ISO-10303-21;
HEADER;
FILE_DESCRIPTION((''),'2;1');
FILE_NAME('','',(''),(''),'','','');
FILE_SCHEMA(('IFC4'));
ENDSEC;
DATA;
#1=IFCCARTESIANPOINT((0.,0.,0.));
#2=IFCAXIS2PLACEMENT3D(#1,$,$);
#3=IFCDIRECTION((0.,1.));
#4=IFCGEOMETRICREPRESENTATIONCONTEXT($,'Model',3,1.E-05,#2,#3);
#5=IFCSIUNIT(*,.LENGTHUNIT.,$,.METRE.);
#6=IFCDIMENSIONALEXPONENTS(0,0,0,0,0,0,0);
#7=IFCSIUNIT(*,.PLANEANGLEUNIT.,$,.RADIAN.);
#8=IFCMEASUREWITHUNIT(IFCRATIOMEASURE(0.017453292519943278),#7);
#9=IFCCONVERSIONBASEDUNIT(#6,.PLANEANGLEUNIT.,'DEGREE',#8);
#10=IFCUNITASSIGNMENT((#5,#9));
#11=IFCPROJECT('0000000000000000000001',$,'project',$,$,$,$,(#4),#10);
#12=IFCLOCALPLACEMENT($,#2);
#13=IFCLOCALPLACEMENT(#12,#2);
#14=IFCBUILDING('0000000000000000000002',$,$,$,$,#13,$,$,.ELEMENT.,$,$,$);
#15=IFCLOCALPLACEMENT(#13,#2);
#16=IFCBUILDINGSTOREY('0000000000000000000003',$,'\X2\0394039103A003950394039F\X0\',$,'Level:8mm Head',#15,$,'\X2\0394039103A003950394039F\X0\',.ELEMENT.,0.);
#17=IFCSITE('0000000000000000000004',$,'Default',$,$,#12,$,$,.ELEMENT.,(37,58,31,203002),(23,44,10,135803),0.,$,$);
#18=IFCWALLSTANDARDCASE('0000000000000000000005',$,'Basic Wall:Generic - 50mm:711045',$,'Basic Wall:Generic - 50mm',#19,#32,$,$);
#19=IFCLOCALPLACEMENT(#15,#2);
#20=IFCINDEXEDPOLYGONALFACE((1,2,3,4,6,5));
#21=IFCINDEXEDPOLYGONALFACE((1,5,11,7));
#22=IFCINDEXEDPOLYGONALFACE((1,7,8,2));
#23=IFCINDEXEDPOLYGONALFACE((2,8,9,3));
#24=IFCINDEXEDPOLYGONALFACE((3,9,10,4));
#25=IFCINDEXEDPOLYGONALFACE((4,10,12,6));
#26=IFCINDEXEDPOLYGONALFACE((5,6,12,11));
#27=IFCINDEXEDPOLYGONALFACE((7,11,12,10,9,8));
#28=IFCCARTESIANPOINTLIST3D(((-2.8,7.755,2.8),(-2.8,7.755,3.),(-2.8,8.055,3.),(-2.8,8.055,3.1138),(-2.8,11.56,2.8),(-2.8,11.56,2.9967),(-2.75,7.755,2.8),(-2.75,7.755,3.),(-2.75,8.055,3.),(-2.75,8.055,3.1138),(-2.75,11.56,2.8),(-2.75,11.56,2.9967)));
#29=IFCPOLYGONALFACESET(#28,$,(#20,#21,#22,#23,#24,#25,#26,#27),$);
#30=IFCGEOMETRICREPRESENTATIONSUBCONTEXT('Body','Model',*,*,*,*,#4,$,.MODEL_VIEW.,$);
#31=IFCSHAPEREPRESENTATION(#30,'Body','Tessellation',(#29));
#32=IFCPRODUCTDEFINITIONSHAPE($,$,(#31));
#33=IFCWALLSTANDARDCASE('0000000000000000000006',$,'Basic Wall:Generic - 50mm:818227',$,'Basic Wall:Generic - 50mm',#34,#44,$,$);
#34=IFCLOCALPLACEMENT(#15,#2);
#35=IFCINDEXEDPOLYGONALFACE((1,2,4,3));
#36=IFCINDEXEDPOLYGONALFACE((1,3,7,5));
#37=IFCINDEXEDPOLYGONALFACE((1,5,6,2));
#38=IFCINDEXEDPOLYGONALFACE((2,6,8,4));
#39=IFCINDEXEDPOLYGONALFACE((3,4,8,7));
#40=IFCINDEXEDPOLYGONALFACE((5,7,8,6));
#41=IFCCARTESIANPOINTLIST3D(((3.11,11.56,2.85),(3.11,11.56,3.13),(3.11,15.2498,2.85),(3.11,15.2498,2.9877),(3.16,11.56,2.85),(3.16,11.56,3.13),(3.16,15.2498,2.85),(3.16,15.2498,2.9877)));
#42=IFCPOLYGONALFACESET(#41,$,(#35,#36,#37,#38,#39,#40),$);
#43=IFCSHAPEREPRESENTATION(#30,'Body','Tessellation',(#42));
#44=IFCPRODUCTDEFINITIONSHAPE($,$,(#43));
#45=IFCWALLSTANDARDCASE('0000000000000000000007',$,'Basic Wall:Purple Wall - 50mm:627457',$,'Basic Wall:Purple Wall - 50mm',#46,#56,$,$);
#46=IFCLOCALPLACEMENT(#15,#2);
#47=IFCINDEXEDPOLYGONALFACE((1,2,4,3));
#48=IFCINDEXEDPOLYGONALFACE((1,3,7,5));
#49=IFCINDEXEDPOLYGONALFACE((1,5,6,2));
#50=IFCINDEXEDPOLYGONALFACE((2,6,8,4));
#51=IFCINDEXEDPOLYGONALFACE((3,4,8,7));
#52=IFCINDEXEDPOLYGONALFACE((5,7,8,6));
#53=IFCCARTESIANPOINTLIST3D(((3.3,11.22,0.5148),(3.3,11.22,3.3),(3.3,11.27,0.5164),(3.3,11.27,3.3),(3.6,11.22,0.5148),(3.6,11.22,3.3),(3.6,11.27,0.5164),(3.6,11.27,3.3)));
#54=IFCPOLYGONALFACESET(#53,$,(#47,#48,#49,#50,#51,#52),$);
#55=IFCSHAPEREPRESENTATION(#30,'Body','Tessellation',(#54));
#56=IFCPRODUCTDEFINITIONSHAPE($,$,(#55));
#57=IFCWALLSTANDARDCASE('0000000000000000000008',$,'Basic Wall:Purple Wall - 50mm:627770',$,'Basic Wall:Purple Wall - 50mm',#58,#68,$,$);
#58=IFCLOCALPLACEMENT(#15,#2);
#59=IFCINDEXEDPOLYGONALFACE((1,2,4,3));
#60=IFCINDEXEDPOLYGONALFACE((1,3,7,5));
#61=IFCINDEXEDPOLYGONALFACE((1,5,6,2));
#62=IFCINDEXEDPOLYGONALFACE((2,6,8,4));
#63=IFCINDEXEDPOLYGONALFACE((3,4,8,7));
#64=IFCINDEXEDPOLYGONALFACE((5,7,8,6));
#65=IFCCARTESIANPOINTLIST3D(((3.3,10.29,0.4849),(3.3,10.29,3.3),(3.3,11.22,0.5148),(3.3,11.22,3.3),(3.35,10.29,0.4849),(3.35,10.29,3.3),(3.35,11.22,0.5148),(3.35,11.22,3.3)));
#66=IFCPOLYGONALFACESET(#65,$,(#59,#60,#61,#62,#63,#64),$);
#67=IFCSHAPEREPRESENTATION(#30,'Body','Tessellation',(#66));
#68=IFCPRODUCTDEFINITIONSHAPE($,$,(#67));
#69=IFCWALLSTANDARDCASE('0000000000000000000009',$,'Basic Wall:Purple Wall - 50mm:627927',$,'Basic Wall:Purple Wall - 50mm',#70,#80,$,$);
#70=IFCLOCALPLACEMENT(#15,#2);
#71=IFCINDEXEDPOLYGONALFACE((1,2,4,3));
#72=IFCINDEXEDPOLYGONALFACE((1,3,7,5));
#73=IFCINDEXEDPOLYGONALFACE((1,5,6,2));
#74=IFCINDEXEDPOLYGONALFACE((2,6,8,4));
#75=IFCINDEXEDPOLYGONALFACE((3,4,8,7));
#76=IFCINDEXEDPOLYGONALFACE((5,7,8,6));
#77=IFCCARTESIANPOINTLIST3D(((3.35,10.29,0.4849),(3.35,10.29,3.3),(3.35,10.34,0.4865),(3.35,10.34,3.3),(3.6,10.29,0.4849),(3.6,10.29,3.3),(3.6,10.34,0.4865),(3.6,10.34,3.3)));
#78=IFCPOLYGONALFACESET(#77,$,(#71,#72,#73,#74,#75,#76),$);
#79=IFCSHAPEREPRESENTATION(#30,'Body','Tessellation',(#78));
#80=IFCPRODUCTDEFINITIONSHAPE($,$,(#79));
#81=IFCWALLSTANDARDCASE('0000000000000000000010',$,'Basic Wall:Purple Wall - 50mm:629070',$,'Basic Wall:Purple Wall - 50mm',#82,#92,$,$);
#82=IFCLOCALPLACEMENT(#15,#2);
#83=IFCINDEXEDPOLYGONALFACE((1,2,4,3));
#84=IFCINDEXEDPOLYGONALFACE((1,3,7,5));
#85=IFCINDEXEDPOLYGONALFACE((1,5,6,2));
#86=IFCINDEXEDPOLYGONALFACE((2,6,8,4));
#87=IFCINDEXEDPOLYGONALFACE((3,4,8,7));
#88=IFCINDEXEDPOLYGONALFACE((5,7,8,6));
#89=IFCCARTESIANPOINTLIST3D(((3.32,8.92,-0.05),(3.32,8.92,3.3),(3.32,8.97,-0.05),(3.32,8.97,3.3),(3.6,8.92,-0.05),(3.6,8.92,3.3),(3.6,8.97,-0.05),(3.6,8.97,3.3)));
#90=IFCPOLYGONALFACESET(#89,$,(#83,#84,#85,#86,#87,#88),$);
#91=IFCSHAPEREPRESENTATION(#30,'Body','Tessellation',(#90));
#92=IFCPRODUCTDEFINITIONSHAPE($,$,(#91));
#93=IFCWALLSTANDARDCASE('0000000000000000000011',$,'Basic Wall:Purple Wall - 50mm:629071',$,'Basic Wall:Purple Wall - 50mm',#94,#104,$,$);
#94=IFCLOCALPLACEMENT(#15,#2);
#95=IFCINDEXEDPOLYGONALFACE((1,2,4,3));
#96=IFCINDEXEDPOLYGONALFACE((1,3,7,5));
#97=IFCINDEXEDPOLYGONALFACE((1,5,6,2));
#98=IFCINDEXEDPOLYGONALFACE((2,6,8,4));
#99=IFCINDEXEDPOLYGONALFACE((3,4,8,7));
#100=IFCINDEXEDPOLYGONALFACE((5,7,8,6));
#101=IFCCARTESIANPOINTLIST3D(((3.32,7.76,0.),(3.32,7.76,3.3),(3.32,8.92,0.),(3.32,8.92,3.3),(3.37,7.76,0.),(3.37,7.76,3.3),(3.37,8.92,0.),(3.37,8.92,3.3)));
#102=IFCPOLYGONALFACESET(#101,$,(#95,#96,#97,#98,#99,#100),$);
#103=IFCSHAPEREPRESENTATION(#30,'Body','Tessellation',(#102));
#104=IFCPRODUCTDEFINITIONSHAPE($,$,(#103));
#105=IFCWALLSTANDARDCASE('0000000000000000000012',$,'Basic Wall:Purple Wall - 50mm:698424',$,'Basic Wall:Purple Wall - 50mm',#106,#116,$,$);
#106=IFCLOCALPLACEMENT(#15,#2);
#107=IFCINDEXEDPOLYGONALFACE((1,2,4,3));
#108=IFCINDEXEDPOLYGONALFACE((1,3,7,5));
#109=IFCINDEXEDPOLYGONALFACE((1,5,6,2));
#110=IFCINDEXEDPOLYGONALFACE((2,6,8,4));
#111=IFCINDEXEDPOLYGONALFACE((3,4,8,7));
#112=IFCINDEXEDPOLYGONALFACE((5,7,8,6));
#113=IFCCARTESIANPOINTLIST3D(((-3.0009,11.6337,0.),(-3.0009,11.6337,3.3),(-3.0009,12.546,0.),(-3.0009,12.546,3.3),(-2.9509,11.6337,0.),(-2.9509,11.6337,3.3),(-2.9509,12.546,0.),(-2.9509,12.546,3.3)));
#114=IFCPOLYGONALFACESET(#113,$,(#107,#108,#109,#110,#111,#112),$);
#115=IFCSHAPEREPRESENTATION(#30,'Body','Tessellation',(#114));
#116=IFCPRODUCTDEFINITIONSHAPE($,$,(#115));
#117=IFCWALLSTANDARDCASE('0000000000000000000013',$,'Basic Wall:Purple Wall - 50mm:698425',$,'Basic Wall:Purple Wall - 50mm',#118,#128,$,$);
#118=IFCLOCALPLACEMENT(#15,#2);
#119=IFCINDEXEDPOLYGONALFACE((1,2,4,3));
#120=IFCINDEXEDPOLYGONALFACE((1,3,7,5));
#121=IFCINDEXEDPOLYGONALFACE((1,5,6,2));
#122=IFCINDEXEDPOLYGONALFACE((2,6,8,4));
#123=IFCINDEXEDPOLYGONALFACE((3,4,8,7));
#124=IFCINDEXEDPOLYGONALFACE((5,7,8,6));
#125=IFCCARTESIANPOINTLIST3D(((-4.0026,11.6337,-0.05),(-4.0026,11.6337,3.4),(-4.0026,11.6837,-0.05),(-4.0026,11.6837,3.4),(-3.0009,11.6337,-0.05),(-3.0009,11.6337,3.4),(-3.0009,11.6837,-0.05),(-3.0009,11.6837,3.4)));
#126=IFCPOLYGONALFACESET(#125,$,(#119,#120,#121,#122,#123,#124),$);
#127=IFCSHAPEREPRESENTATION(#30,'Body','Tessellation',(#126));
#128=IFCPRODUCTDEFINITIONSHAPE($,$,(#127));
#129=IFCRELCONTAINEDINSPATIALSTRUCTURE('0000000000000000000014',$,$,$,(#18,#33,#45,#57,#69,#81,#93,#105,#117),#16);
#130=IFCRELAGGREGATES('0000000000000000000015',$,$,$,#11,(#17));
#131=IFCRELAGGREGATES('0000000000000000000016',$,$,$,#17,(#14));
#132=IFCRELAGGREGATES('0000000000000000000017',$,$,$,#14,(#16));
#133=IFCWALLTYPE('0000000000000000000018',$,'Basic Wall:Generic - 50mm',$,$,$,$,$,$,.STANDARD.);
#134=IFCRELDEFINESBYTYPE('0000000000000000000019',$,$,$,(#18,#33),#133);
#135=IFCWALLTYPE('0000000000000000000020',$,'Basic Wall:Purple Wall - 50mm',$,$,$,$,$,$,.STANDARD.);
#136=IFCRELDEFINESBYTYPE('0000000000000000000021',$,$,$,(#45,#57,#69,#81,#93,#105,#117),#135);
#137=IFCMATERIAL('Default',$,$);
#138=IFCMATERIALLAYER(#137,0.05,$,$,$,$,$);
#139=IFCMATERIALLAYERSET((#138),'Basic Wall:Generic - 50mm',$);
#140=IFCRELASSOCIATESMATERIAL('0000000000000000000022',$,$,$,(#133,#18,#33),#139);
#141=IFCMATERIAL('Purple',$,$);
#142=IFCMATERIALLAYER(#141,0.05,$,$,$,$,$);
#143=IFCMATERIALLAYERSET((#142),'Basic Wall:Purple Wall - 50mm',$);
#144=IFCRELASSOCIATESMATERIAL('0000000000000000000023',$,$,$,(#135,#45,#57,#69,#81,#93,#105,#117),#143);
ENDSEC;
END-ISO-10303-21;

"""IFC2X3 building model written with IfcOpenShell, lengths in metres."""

from ifc_helpers import new_model, entity, si_unit, converted_unit, direction, frame, frame_2d, origin, place, context, subcontext, project, spatial, polyline, rectangle, extrude, clip, bounded_halfspace, material, layer, layer_set, layer_usage, type_object, element, save


model = new_model("IFC2X3")

# Units and contexts
model_context = context("Model", 3, precision=1e-05, world=origin(), true_north=direction((0.0, 1.0)))
body_context = subcontext(model_context, "Body", "Model", "MODEL_VIEW")
ifc_project = project(units=[si_unit("LENGTHUNIT", "METRE"), converted_unit("PLANEANGLEUNIT", "DEGREE", entity("IfcRatioMeasure", 0.017453292519943278), si_unit("PLANEANGLEUNIT", "RADIAN"), dimensions=[0, 0, 0, 0, 0, 0, 0])], contexts=[model_context])

# Site, building, storey
site_placement = place(None, origin())
site = spatial("IfcSite", under=ifc_project, at=site_placement, Name="Default", CompositionType="ELEMENT", RefLatitude=(37, 58, 31, 203002), RefLongitude=(23, 44, 10, 135803), RefElevation=0.0)
building_placement = place(site_placement, origin())
building = spatial("IfcBuilding", under=site, at=building_placement, CompositionType="ELEMENT")
storey_placement = place(building_placement, origin())
storey = spatial("IfcBuildingStorey", under=building, at=storey_placement, Name="ΔΑΠΕΔΟ", ObjectType="Level:8mm Head", LongName="ΔΑΠΕΔΟ", CompositionType="ELEMENT", Elevation=0.0)

# Walls
ifc_material_1 = material(Name="Default")
ifc_layer_1 = layer(ifc_material_1, 0.05)
ifc_layer_set_1 = layer_set([ifc_layer_1], Name="Basic Wall:Generic - 50mm")
ifc_layer_usage_1 = layer_usage(ifc_layer_set_1, "AXIS2", "NEGATIVE", 0.025)
wall_type_1 = type_object("IfcWallType", Name="Basic Wall:Generic - 50mm", PredefinedType="STANDARD", material=ifc_layer_set_1)
wall_1_placement = place(storey_placement, frame((-2.775, 11.56, 2.8), z_axis=(0.0, 0.0, 1.0), x_axis=(0.0, -1.0, 0.0)))
element("IfcWallStandardCase", 1, at=wall_1_placement, inside=storey, type_object=wall_type_1, material=ifc_layer_usage_1, Name="Basic Wall:Generic - 50mm:711045", ObjectType="Basic Wall:Generic - 50mm", context=body_context, shape_type="Clipping", body=[
    clip(clip(clip(extrude(rectangle(XDim=3.805, YDim=0.05, at=frame_2d((1.9025, 0.0), x_axis=(-1.0, 0.0))), origin(), (0.0, 0.0, 1.0), 0.3138), bounded_halfspace(frame((0.0, -0.025, 0.1967), z_axis=(0.033402, 0.0, -0.999442), x_axis=(-0.999442, 0.0, -0.033402)), True, frame((0.0, -0.025, 0.1967)), polyline([(0.0, 0.0), (3.505, 0.0), (3.505, 0.05), (0.0, 0.05), (0.0, 0.0)]))), bounded_halfspace(frame((3.505, -0.025, 0.2), z_axis=(0.0, 0.0, -1.0), x_axis=(0.0, 1.0, 0.0)), True, frame((3.505, -0.025, 0.2)), polyline([(0.0, 0.0), (0.3, 0.0), (0.3, 0.05), (0.0, 0.05), (0.0, 0.0)]))), bounded_halfspace(frame((3.505, -0.025, 0.2), z_axis=(0.0, 0.0, -1.0), x_axis=(0.0, 1.0, 0.0)), True, frame((3.505, -0.025, 0.2)), polyline([(0.0, 0.0), (0.3, 0.0), (0.3, 0.05), (0.0, 0.05), (0.0, 0.0)]))),
])
wall_2_placement = place(storey_placement, frame((3.135, 11.56, 2.85), z_axis=(0.0, 0.0, 1.0), x_axis=(0.0, 1.0, 0.0)))
element("IfcWallStandardCase", 2, at=wall_2_placement, inside=storey, type_object=wall_type_1, material=ifc_layer_usage_1, Name="Basic Wall:Generic - 50mm:818227", ObjectType="Basic Wall:Generic - 50mm", context=body_context, shape_type="Clipping", body=[
    clip(extrude(rectangle(XDim=3.6898, YDim=0.05, at=frame_2d((1.8449, 0.0), x_axis=(-1.0, 0.0))), origin(), (0.0, 0.0, 1.0), 0.28), bounded_halfspace(frame((0.0, -0.025, 0.28), z_axis=(-0.038534, 0.0, -0.999257), x_axis=(0.999257, 0.0, -0.038534)), True, frame((0.0, -0.025, 0.28)), polyline([(0.0, 0.0), (3.6898, 0.0), (3.6898, 0.05), (0.0, 0.05), (0.0, 0.0)]))),
])
ifc_material_2 = material(Name="Purple")
ifc_layer_2 = layer(ifc_material_2, 0.05)
ifc_layer_set_2 = layer_set([ifc_layer_2], Name="Basic Wall:Purple Wall - 50mm")
ifc_layer_usage_2 = layer_usage(ifc_layer_set_2, "AXIS2", "POSITIVE", -0.025)
wall_type_2 = type_object("IfcWallType", Name="Basic Wall:Purple Wall - 50mm", PredefinedType="STANDARD", material=ifc_layer_set_2)
wall_3_placement = place(storey_placement, frame((3.6, 11.245, 0.5148), z_axis=(0.0, 0.0, 1.0), x_axis=(-1.0, 0.0, 0.0)))
element("IfcWallStandardCase", 3, at=wall_3_placement, inside=storey, type_object=wall_type_2, material=ifc_layer_usage_2, Name="Basic Wall:Purple Wall - 50mm:627457", ObjectType="Basic Wall:Purple Wall - 50mm", context=body_context, shape_type="Clipping", body=[
    clip(extrude(rectangle(XDim=0.3, YDim=0.05, at=frame_2d((0.15, 0.0), x_axis=(-1.0, 0.0))), origin(), (0.0, 0.0, 1.0), 2.7852), bounded_halfspace(frame((0.3, -0.025, 0.0016), z_axis=(0.0, 0.032108, 0.999484), x_axis=(-1.0, 0.0, 0.0)), True, frame((0.3, -0.025, 0.0016)), polyline([(0.0, 0.0), (0.0, 0.05), (-0.05, 0.05), (-0.3, 0.05), (-0.3, 0.0), (0.0, 0.0)]))),
])
wall_4_placement = place(storey_placement, frame((3.325, 11.22, 0.4849), z_axis=(0.0, 0.0, 1.0), x_axis=(0.0, -1.0, 0.0)))
element("IfcWallStandardCase", 4, at=wall_4_placement, inside=storey, type_object=wall_type_2, material=ifc_layer_usage_2, Name="Basic Wall:Purple Wall - 50mm:627770", ObjectType="Basic Wall:Purple Wall - 50mm", context=body_context, shape_type="Clipping", body=[
    clip(extrude(rectangle(XDim=0.93, YDim=0.05, at=frame_2d((0.465, 0.0), x_axis=(-1.0, 0.0))), origin(), (0.0, 0.0, 1.0), 2.8151), bounded_halfspace(frame((0.93, -0.025, 0.0), z_axis=(0.032108, 0.0, 0.999484), x_axis=(0.0, 1.0, 0.0)), True, frame((0.93, -0.025, 0.0)), polyline([(0.0, 0.0), (0.0, 0.05), (-0.05, 0.05), (-0.93, 0.05), (-0.93, 0.0), (0.0, 0.0)]))),
])
wall_5_placement = place(storey_placement, frame((3.35, 10.315, 0.4849)))
element("IfcWallStandardCase", 5, at=wall_5_placement, inside=storey, type_object=wall_type_2, material=ifc_layer_usage_2, Name="Basic Wall:Purple Wall - 50mm:627927", ObjectType="Basic Wall:Purple Wall - 50mm", context=body_context, shape_type="Clipping", body=[
    clip(extrude(rectangle(XDim=0.25, YDim=0.05, at=frame_2d((0.125, 0.0), x_axis=(-1.0, 0.0))), origin(), (0.0, 0.0, 1.0), 2.8151), bounded_halfspace(frame((0.25, -0.025, 0.0), z_axis=(0.0, -0.032108, 0.999484), x_axis=(1.0, 0.0, 0.0)), True, frame((0.25, -0.025, 0.0)), polyline([(0.0, 0.0), (0.0, 0.05), (-0.25, 0.05), (-0.25, 0.0), (-0.07, 0.0), (-0.06, 0.0), (0.0, 0.0)]))),
])
wall_6_placement = place(storey_placement, frame((3.6, 8.945, -0.05), z_axis=(0.0, 0.0, 1.0), x_axis=(-1.0, 0.0, 0.0)))
element("IfcWallStandardCase", 6, at=wall_6_placement, inside=storey, type_object=wall_type_2, material=ifc_layer_usage_2, Name="Basic Wall:Purple Wall - 50mm:629070", ObjectType="Basic Wall:Purple Wall - 50mm", context=body_context, shape_type="Clipping", body=[
    clip(extrude(rectangle(XDim=0.28, YDim=0.05, at=frame_2d((0.14, 0.0), x_axis=(-1.0, 0.0))), origin(), (0.0, 0.0, 1.0), 3.35), bounded_halfspace(frame((0.28, -0.025, 0.0), z_axis=(0.0, 0.0, 1.0), x_axis=(0.0, -1.0, 0.0)), True, frame((0.28, -0.025, 0.0), z_axis=(0.0, 0.0, 1.0), x_axis=(0.0, -1.0, 0.0)), polyline([(0.0, 0.0), (-0.05, 0.0), (-0.05, -0.28), (0.0, -0.28), (0.0, 0.0)]))),
])
wall_7_placement = place(storey_placement, frame((3.345, 8.92, 0.0), z_axis=(0.0, 0.0, 1.0), x_axis=(0.0, -1.0, 0.0)))
element("IfcWallStandardCase", 7, at=wall_7_placement, inside=storey, type_object=wall_type_2, material=ifc_layer_usage_2, Name="Basic Wall:Purple Wall - 50mm:629071", ObjectType="Basic Wall:Purple Wall - 50mm", context=body_context, shape_type="SweptSolid", body=[
    extrude(rectangle(XDim=1.16, YDim=0.05, at=frame_2d((0.58, 0.0), x_axis=(-1.0, 0.0))), origin(), (0.0, 0.0, 1.0), 3.3),
])
ifc_layer_usage_3 = layer_usage(ifc_layer_set_2, "AXIS2", "NEGATIVE", 0.025)
wall_8_placement = place(storey_placement, frame((-2.9759, 12.546, 0.0), z_axis=(0.0, 0.0, 1.0), x_axis=(0.0, -1.0, 0.0)))
element("IfcWallStandardCase", 8, at=wall_8_placement, inside=storey, type_object=wall_type_2, material=ifc_layer_usage_3, Name="Basic Wall:Purple Wall - 50mm:698424", ObjectType="Basic Wall:Purple Wall - 50mm", context=body_context, shape_type="SweptSolid", body=[
    extrude(rectangle(XDim=0.9123, YDim=0.05, at=frame_2d((0.4561, 0.0), x_axis=(-1.0, 0.0))), origin(), (0.0, 0.0, 1.0), 3.3),
])
wall_9_placement = place(storey_placement, frame((-3.0009, 11.6587, -0.05), z_axis=(0.0, 0.0, 1.0), x_axis=(-1.0, 0.0, 0.0)))
element("IfcWallStandardCase", 9, at=wall_9_placement, inside=storey, type_object=wall_type_2, material=ifc_layer_usage_3, Name="Basic Wall:Purple Wall - 50mm:698425", ObjectType="Basic Wall:Purple Wall - 50mm", context=body_context, shape_type="SweptSolid", body=[
    extrude(rectangle(XDim=1.0016, YDim=0.05, at=frame_2d((0.5008, 0.0), x_axis=(-1.0, 0.0))), origin(), (0.0, 0.0, 1.0), 3.45),
])

save(model, "model.ifc")
